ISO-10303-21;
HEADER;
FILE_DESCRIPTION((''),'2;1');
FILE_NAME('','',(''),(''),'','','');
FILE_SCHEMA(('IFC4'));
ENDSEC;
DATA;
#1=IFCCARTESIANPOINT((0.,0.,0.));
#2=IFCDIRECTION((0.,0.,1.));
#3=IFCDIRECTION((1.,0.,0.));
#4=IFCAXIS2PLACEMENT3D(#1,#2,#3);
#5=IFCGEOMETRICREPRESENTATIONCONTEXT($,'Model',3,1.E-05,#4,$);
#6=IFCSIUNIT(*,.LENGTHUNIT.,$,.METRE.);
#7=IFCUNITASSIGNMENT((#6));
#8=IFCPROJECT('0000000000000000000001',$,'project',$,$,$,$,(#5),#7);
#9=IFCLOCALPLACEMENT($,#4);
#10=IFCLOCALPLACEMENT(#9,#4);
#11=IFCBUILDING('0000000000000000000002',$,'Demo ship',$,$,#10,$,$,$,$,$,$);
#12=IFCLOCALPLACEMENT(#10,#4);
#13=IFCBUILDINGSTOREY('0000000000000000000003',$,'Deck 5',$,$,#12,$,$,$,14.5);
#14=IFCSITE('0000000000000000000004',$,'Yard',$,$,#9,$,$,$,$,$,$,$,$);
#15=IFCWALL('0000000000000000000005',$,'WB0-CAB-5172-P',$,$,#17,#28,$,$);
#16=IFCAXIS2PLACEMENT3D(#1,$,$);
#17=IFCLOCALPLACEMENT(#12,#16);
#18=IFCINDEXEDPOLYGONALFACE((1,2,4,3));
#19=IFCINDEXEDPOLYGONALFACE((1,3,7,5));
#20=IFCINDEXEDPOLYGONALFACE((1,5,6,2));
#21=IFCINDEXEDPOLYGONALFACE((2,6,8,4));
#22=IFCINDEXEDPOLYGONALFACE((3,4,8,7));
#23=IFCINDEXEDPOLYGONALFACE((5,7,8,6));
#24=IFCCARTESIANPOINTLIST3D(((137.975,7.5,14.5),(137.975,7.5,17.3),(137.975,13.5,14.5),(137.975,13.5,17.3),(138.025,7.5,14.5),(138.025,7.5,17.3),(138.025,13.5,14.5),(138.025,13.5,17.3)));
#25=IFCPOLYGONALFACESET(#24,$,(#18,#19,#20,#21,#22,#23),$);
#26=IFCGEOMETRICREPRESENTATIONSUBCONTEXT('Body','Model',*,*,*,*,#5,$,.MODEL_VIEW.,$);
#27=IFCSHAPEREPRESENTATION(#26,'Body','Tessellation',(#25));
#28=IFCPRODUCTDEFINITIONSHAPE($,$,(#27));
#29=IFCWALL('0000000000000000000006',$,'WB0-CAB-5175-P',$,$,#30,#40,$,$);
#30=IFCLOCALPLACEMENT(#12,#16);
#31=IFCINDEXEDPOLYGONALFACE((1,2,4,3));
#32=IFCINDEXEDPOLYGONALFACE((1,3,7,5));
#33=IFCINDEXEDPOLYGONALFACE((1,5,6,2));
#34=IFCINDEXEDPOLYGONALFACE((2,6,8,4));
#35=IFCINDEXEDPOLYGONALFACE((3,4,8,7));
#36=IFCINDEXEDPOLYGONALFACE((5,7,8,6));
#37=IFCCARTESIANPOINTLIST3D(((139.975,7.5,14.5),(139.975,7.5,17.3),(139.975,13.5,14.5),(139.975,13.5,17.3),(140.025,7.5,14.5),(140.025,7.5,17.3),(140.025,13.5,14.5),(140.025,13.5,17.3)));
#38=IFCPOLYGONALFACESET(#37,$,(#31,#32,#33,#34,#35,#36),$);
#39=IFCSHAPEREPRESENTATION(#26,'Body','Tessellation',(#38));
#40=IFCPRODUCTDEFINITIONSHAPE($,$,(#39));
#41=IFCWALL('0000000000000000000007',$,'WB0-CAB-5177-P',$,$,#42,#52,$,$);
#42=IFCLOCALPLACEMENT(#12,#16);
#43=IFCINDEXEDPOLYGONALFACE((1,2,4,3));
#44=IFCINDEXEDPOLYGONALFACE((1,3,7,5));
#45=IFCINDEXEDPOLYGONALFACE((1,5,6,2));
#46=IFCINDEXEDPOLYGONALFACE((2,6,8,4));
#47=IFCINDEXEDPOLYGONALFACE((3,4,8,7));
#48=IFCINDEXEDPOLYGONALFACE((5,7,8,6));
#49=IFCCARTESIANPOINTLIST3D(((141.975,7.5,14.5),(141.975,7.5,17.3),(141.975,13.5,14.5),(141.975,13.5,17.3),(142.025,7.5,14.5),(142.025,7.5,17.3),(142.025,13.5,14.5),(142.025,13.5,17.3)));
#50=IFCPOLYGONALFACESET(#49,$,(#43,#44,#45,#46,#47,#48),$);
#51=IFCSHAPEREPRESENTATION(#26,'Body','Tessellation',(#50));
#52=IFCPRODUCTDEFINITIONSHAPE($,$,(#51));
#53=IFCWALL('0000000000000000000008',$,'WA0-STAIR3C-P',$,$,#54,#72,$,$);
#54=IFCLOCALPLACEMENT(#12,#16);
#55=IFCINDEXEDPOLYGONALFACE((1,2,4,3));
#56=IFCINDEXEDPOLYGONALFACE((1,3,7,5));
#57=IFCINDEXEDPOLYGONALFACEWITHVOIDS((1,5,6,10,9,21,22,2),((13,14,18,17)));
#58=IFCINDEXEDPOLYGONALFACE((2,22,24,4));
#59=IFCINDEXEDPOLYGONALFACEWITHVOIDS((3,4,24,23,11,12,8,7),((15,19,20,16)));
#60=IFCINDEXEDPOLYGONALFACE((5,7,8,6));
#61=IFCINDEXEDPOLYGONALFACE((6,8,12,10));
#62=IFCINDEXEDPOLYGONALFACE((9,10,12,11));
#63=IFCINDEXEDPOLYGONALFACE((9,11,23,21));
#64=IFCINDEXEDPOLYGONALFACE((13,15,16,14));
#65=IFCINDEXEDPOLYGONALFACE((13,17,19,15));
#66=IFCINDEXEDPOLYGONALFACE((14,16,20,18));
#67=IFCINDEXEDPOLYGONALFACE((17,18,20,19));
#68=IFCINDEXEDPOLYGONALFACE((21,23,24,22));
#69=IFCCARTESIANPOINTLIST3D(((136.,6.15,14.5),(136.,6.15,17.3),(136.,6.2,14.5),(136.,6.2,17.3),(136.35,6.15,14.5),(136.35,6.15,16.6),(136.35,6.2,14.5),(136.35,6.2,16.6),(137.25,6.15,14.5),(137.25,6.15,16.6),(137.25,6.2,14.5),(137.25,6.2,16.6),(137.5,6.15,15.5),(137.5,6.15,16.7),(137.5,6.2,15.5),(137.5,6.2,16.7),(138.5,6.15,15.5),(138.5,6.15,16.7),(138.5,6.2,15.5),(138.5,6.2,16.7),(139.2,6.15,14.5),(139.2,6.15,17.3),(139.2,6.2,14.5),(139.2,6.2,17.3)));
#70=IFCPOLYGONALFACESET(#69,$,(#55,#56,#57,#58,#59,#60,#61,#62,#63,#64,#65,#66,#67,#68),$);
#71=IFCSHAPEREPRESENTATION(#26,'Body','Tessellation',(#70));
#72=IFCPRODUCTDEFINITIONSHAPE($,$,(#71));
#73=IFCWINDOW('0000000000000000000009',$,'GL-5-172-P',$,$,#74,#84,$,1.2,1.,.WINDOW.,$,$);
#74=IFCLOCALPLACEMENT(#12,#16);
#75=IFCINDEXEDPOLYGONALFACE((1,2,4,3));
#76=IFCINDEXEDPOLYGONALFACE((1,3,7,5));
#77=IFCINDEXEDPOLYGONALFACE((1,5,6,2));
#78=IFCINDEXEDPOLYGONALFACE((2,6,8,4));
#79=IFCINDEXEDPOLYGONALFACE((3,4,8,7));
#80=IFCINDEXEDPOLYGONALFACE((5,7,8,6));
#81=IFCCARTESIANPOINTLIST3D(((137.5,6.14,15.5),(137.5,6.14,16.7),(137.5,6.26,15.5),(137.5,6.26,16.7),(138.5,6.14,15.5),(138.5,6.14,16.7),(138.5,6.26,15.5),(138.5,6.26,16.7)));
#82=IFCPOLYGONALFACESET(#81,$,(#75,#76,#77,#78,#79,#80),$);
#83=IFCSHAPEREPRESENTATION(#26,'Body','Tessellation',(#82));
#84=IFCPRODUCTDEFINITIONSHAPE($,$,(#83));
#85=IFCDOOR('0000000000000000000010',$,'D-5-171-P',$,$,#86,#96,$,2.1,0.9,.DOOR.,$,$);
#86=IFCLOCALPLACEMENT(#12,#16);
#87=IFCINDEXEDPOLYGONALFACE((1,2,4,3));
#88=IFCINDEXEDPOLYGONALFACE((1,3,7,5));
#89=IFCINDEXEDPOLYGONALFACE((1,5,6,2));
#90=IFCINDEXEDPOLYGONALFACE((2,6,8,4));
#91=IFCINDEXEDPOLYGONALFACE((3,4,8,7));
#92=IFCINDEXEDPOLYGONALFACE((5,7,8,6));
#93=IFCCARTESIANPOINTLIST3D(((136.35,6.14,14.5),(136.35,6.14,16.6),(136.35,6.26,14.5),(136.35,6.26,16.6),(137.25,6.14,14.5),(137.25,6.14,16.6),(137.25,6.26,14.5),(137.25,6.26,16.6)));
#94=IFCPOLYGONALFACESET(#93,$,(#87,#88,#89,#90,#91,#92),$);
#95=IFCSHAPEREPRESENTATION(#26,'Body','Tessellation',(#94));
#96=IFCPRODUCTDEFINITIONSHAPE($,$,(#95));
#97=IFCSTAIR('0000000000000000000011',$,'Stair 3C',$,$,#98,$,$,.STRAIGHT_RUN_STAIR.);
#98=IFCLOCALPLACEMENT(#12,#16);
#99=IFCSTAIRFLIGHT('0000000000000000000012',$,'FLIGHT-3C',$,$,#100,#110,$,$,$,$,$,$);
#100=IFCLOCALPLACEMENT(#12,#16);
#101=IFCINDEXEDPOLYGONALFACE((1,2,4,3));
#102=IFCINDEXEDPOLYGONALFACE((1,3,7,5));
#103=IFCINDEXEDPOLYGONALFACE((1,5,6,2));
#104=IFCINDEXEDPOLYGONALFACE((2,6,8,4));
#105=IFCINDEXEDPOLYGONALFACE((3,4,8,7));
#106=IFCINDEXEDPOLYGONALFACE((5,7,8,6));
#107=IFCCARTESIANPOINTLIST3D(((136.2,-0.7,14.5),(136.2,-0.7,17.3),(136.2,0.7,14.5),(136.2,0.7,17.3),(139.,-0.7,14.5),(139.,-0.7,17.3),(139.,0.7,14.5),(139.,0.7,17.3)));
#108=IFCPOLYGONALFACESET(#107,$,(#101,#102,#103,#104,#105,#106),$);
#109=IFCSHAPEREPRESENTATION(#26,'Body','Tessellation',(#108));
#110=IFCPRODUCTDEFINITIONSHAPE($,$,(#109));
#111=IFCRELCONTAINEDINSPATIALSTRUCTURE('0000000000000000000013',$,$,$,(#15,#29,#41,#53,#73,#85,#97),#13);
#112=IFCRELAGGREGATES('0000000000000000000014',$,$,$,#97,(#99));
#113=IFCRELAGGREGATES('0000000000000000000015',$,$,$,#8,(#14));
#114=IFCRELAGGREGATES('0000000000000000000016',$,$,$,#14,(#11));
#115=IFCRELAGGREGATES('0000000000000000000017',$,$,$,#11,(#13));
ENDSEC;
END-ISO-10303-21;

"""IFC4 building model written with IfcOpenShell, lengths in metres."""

from ifc_helpers import new_model, si_unit, frame, frame_2d, origin, origin_with_axes, place, context, subcontext, project, spatial, rectangle, extrude, element, fill, aggregate, save


model = new_model("IFC4")

# Units and contexts
model_context = context("Model", 3, precision=1e-05, world=origin_with_axes())
body_context = subcontext(model_context, "Body", "Model", "MODEL_VIEW")
ifc_project = project(units=[si_unit("LENGTHUNIT", "METRE")], contexts=[model_context])

# Site, building, storey
site_placement = place(None, origin_with_axes())
site = spatial("IfcSite", under=ifc_project, at=site_placement, Name="Yard")
building_placement = place(site_placement, origin_with_axes())
building = spatial("IfcBuilding", under=site, at=building_placement, Name="Demo ship")
storey_placement = place(building_placement, origin_with_axes())
storey = spatial("IfcBuildingStorey", under=building, at=storey_placement, Name="Deck 5", Elevation=14.5)

# Walls
for number, where, z_axis, x_axis, name in (
    (1, (137.975, 7.5, 14.5), (0.0, 0.0, 1.0), (1.0, 0.0, 0.0), "WB0-CAB-5172-P"),
    (2, (139.975, 7.5, 14.5), (0.0, 0.0, 1.0), (1.0, 0.0, 0.0), "WB0-CAB-5175-P"),
    (3, (141.975, 7.5, 14.5), (0.0, 0.0, 1.0), (1.0, 0.0, 0.0), "WB0-CAB-5177-P"),
):
    element("IfcWall", number, at=place(storey_placement, frame(where, z_axis=z_axis, x_axis=x_axis)), inside=storey, Name=name, context=body_context, shape_type="SweptSolid", body=[
        extrude(rectangle(XDim=0.05, YDim=6.0, at=frame_2d((0.025, 3.0))), origin(), (0.0, 0.0, 1.0), 2.8),
    ])

# Wall, openings, window, door
wall_1_placement = place(storey_placement, frame((136.0, 6.15, 14.5), z_axis=(0.0, 0.0, 1.0), x_axis=(1.0, 0.0, 0.0)))
wall_1 = element("IfcWall", 4, at=wall_1_placement, inside=storey, Name="WA0-STAIR3C-P", context=body_context, shape_type="SweptSolid", body=[
    extrude(rectangle(XDim=3.2, YDim=0.05, at=frame_2d((1.6, 0.025))), origin(), (0.0, 0.0, 1.0), 2.8),
])
opening_1_placement = place(None, frame((137.5, 6.14, 15.5), z_axis=(0.0, 0.0, 1.0), x_axis=(1.0, 0.0, 0.0)))
opening_1 = element("IfcOpeningElement", 5, at=opening_1_placement, cuts=wall_1, context=body_context, shape_type="SweptSolid", body=[
    extrude(rectangle(XDim=1.0, YDim=0.12, at=frame_2d((0.5, 0.06))), origin(), (0.0, 0.0, 1.0), 1.2),
])
opening_2_placement = place(None, frame((136.35, 6.14, 14.5), z_axis=(0.0, 0.0, 1.0), x_axis=(1.0, 0.0, 0.0)))
opening_2 = element("IfcOpeningElement", 6, at=opening_2_placement, cuts=wall_1, context=body_context, shape_type="SweptSolid", body=[
    extrude(rectangle(XDim=0.9, YDim=0.12, at=frame_2d((0.45, 0.06))), origin(), (0.0, 0.0, 1.0), 2.1),
])
window_placement = place(storey_placement, frame((137.5, 6.14, 15.5), z_axis=(0.0, 0.0, 1.0), x_axis=(1.0, 0.0, 0.0)))
window = element("IfcWindow", 7, at=window_placement, inside=storey, Name="GL-5-172-P", OverallHeight=1.2, OverallWidth=1.0, PredefinedType="WINDOW", context=body_context, shape_type="SweptSolid", body=[
    extrude(rectangle(XDim=1.0, YDim=0.12, at=frame_2d((0.5, 0.06))), origin(), (0.0, 0.0, 1.0), 1.2),
])
fill(opening_1, window)
door_1_placement = place(storey_placement, frame((136.35, 6.14, 14.5), z_axis=(0.0, 0.0, 1.0), x_axis=(1.0, 0.0, 0.0)))
door_1 = element("IfcDoor", 8, at=door_1_placement, inside=storey, Name="D-5-171-P", OverallHeight=2.1, OverallWidth=0.9, PredefinedType="DOOR", context=body_context, shape_type="SweptSolid", body=[
    extrude(rectangle(XDim=0.9, YDim=0.12, at=frame_2d((0.45, 0.06))), origin(), (0.0, 0.0, 1.0), 2.1),
])
fill(opening_2, door_1)

# Stair, stair flight
stair_placement = place(storey_placement, frame((136.2, -0.7, 14.5), z_axis=(0.0, 0.0, 1.0), x_axis=(1.0, 0.0, 0.0)))
stair = element("IfcStair", 9, at=stair_placement, inside=storey, Name="Stair 3C", PredefinedType="STRAIGHT_RUN_STAIR")
stair_flight_placement = place(stair_placement, origin_with_axes())
stair_flight = element("IfcStairFlight", 10, at=stair_flight_placement, Name="FLIGHT-3C", context=body_context, shape_type="SweptSolid", body=[
    extrude(rectangle(XDim=2.8, YDim=1.4, at=frame_2d((1.4, 0.7))), origin(), (0.0, 0.0, 1.0), 2.8),
])
aggregate(stair, [stair_flight])

save(model, "model.ifc")
